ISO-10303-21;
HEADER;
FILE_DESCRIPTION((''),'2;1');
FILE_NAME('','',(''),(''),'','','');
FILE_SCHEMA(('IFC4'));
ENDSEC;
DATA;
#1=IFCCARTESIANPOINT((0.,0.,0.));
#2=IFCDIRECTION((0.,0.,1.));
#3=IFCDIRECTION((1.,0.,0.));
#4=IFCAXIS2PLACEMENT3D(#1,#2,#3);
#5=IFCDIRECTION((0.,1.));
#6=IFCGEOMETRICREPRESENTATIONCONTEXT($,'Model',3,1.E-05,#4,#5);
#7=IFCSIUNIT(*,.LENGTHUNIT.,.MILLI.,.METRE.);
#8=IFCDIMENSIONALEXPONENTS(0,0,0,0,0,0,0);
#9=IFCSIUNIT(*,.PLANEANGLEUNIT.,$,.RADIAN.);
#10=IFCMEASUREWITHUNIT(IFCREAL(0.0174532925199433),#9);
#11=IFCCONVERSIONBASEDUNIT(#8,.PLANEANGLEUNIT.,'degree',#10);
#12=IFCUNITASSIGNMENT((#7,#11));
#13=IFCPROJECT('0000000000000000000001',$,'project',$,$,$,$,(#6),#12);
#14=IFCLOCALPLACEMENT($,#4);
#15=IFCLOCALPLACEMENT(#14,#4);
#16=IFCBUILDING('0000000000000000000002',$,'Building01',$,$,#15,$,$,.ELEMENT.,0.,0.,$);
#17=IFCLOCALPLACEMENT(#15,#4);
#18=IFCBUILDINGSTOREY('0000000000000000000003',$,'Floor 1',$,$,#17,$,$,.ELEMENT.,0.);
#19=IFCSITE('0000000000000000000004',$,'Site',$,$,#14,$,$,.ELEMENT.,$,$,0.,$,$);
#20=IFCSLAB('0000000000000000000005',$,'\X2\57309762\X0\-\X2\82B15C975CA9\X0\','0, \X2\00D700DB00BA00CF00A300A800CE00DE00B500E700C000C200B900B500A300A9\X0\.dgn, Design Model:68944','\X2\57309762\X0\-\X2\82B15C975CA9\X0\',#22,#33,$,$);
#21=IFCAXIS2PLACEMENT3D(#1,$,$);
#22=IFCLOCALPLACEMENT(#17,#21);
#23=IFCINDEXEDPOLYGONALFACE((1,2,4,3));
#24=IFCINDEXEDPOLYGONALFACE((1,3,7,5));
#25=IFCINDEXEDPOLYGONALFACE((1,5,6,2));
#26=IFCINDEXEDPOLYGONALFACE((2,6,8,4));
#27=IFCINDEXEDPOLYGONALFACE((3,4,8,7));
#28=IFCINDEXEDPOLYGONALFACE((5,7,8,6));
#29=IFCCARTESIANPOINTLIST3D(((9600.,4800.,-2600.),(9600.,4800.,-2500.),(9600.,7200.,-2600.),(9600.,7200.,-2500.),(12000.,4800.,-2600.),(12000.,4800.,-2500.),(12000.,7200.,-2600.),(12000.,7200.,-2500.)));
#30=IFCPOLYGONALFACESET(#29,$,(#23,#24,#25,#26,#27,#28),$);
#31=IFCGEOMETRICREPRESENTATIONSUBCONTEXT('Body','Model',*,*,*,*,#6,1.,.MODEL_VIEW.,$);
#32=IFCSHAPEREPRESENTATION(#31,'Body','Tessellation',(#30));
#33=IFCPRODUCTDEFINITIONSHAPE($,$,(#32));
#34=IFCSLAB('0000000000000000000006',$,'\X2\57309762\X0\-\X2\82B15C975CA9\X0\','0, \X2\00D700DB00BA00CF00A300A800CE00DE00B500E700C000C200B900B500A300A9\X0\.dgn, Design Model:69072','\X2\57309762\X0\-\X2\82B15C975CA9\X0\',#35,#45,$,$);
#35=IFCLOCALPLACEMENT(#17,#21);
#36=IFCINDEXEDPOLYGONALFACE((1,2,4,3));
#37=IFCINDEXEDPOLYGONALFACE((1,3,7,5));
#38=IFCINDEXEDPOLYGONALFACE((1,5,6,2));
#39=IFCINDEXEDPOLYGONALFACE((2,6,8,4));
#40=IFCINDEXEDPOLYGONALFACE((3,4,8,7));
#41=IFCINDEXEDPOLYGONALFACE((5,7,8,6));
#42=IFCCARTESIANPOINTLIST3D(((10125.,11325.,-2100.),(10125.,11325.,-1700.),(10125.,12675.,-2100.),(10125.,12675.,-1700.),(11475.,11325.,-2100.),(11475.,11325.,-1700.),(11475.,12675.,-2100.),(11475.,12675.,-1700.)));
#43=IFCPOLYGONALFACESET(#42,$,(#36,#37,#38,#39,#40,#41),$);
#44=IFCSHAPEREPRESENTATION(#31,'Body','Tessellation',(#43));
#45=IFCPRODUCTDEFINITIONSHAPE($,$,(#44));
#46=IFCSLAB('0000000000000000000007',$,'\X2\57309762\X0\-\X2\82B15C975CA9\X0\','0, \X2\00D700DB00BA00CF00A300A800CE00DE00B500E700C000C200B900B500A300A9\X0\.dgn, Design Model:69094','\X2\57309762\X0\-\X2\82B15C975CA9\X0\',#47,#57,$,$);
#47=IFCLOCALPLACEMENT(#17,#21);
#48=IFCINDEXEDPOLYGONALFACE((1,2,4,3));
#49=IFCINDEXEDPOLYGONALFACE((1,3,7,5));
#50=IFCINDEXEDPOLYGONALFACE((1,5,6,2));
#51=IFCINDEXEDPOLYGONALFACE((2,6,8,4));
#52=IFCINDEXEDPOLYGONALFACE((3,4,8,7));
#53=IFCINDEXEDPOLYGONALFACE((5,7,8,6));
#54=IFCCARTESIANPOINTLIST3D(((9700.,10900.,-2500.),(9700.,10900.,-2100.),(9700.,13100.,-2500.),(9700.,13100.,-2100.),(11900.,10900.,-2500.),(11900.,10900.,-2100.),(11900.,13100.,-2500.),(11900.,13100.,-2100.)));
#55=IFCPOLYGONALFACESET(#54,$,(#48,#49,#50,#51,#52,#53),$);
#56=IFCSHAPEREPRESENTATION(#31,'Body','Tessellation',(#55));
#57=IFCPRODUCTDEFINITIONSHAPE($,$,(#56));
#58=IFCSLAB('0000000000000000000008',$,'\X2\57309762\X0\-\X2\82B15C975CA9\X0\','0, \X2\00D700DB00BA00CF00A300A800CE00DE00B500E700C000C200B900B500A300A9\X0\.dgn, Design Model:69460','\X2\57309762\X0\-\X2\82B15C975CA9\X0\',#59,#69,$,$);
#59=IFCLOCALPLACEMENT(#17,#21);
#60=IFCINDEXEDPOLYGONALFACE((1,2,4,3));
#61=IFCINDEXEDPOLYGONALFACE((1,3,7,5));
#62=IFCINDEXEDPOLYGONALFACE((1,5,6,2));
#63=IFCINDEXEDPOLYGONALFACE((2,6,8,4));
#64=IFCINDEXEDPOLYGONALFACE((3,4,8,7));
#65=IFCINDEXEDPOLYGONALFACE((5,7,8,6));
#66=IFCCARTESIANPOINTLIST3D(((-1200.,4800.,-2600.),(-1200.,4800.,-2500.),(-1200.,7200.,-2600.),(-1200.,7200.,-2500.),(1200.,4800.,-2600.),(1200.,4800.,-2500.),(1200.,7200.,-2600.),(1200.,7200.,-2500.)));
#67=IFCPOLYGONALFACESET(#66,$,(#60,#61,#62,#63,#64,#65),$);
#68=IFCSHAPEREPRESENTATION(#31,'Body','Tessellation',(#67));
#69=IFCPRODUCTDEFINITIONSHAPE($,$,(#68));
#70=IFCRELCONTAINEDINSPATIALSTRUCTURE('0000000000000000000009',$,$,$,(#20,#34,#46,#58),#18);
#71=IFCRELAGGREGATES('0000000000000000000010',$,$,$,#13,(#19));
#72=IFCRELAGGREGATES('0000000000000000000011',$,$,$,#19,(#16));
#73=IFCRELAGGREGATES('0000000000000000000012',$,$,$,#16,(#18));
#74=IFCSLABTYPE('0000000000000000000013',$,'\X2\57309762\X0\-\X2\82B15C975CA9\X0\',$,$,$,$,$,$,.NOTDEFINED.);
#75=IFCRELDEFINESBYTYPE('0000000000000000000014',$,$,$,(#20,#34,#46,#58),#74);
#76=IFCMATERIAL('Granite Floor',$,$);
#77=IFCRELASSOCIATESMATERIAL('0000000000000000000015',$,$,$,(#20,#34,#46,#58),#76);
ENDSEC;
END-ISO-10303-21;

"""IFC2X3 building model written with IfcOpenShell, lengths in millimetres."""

from ifc_helpers import new_model, entity, si_unit, converted_unit, direction, frame, frame_2d, origin_with_axes, place, context, subcontext, project, spatial, rectangle, extrude, material, type_object, element, save


model = new_model("IFC2X3")

# Units and contexts
model_context = context("Model", 3, precision=1e-05, world=origin_with_axes(), true_north=direction((0.0, 1.0)))
body_context = subcontext(model_context, "Body", "Model", "MODEL_VIEW", scale=1.0)
ifc_project = project(units=[si_unit("LENGTHUNIT", "METRE", prefix="MILLI"), converted_unit("PLANEANGLEUNIT", "degree", entity("IfcReal", 0.0174532925199433), si_unit("PLANEANGLEUNIT", "RADIAN"), dimensions=[0, 0, 0, 0, 0, 0, 0])], contexts=[model_context])

# Site, building, storey
site_placement = place(None, origin_with_axes())
site = spatial("IfcSite", under=ifc_project, at=site_placement, Name="Site", CompositionType="ELEMENT", RefElevation=0.0)
building_placement = place(site_placement, origin_with_axes())
building = spatial("IfcBuilding", under=site, at=building_placement, Name="Building01", CompositionType="ELEMENT", ElevationOfRefHeight=0.0, ElevationOfTerrain=0.0)
storey_placement = place(building_placement, origin_with_axes())
storey = spatial("IfcBuildingStorey", under=building, at=storey_placement, Name="Floor 1", CompositionType="ELEMENT", Elevation=0.0)

# Slabs
ifc_material_1 = material(Name="Granite Floor")
slab_type = type_object("IfcSlabType", Name="地面-花岗岩", PredefinedType="NOTDEFINED")
slab_1_placement = place(storey_placement, frame((12000.0, 7200.0, -2500.0), z_axis=(0.0, 0.0, -1.0), x_axis=(0.0, -1.0, 0.0)))
element("IfcSlab", 1, at=slab_1_placement, inside=storey, type_object=slab_type, material=ifc_material_1, Name="地面-花岗岩", Description="0, ×ÛºÏ£¨ÎÞµçÀÂ¹µ£©.dgn, Design Model:68944", ObjectType="地面-花岗岩", context=body_context, shape_type="SweptSolid", body=[
    extrude(rectangle(XDim=2400.0, YDim=2400.0, at=frame_2d((1200.0, 1200.0), x_axis=(1.0, 0.0))), origin_with_axes(), (0.0, 0.0, 1.0), 100.0),
])
slab_2_placement = place(storey_placement, frame((10125.0, 11325.0, -2100.0), z_axis=(0.0, 0.0, 1.0), x_axis=(1.0, 0.0, 0.0)))
element("IfcSlab", 2, at=slab_2_placement, inside=storey, type_object=slab_type, material=ifc_material_1, Name="地面-花岗岩", Description="0, ×ÛºÏ£¨ÎÞµçÀÂ¹µ£©.dgn, Design Model:69072", ObjectType="地面-花岗岩", context=body_context, shape_type="SweptSolid", body=[
    extrude(rectangle(XDim=1350.0, YDim=1350.0, at=frame_2d((675.0, 675.0), x_axis=(1.0, 0.0))), origin_with_axes(), (0.0, 0.0, 1.0), 400.0),
])
slab_3_placement = place(storey_placement, frame((9700.0, 10900.0, -2500.0), z_axis=(0.0, 0.0, 1.0), x_axis=(1.0, 0.0, 0.0)))
element("IfcSlab", 3, at=slab_3_placement, inside=storey, type_object=slab_type, material=ifc_material_1, Name="地面-花岗岩", Description="0, ×ÛºÏ£¨ÎÞµçÀÂ¹µ£©.dgn, Design Model:69094", ObjectType="地面-花岗岩", context=body_context, shape_type="SweptSolid", body=[
    extrude(rectangle(XDim=2200.0, YDim=2200.0, at=frame_2d((1100.0, 1100.0), x_axis=(1.0, 0.0))), origin_with_axes(), (0.0, 0.0, 1.0), 400.0),
])
slab_4_placement = place(storey_placement, frame((1200.0, 7200.0, -2500.0), z_axis=(0.0, 0.0, -1.0), x_axis=(0.0, -1.0, 0.0)))
element("IfcSlab", 4, at=slab_4_placement, inside=storey, type_object=slab_type, material=ifc_material_1, Name="地面-花岗岩", Description="0, ×ÛºÏ£¨ÎÞµçÀÂ¹µ£©.dgn, Design Model:69460", ObjectType="地面-花岗岩", context=body_context, shape_type="SweptSolid", body=[
    extrude(rectangle(XDim=2400.0, YDim=2400.0, at=frame_2d((1200.0, 1200.0), x_axis=(1.0, 0.0))), origin_with_axes(), (0.0, 0.0, 1.0), 100.0),
])

save(model, "model.ifc")
